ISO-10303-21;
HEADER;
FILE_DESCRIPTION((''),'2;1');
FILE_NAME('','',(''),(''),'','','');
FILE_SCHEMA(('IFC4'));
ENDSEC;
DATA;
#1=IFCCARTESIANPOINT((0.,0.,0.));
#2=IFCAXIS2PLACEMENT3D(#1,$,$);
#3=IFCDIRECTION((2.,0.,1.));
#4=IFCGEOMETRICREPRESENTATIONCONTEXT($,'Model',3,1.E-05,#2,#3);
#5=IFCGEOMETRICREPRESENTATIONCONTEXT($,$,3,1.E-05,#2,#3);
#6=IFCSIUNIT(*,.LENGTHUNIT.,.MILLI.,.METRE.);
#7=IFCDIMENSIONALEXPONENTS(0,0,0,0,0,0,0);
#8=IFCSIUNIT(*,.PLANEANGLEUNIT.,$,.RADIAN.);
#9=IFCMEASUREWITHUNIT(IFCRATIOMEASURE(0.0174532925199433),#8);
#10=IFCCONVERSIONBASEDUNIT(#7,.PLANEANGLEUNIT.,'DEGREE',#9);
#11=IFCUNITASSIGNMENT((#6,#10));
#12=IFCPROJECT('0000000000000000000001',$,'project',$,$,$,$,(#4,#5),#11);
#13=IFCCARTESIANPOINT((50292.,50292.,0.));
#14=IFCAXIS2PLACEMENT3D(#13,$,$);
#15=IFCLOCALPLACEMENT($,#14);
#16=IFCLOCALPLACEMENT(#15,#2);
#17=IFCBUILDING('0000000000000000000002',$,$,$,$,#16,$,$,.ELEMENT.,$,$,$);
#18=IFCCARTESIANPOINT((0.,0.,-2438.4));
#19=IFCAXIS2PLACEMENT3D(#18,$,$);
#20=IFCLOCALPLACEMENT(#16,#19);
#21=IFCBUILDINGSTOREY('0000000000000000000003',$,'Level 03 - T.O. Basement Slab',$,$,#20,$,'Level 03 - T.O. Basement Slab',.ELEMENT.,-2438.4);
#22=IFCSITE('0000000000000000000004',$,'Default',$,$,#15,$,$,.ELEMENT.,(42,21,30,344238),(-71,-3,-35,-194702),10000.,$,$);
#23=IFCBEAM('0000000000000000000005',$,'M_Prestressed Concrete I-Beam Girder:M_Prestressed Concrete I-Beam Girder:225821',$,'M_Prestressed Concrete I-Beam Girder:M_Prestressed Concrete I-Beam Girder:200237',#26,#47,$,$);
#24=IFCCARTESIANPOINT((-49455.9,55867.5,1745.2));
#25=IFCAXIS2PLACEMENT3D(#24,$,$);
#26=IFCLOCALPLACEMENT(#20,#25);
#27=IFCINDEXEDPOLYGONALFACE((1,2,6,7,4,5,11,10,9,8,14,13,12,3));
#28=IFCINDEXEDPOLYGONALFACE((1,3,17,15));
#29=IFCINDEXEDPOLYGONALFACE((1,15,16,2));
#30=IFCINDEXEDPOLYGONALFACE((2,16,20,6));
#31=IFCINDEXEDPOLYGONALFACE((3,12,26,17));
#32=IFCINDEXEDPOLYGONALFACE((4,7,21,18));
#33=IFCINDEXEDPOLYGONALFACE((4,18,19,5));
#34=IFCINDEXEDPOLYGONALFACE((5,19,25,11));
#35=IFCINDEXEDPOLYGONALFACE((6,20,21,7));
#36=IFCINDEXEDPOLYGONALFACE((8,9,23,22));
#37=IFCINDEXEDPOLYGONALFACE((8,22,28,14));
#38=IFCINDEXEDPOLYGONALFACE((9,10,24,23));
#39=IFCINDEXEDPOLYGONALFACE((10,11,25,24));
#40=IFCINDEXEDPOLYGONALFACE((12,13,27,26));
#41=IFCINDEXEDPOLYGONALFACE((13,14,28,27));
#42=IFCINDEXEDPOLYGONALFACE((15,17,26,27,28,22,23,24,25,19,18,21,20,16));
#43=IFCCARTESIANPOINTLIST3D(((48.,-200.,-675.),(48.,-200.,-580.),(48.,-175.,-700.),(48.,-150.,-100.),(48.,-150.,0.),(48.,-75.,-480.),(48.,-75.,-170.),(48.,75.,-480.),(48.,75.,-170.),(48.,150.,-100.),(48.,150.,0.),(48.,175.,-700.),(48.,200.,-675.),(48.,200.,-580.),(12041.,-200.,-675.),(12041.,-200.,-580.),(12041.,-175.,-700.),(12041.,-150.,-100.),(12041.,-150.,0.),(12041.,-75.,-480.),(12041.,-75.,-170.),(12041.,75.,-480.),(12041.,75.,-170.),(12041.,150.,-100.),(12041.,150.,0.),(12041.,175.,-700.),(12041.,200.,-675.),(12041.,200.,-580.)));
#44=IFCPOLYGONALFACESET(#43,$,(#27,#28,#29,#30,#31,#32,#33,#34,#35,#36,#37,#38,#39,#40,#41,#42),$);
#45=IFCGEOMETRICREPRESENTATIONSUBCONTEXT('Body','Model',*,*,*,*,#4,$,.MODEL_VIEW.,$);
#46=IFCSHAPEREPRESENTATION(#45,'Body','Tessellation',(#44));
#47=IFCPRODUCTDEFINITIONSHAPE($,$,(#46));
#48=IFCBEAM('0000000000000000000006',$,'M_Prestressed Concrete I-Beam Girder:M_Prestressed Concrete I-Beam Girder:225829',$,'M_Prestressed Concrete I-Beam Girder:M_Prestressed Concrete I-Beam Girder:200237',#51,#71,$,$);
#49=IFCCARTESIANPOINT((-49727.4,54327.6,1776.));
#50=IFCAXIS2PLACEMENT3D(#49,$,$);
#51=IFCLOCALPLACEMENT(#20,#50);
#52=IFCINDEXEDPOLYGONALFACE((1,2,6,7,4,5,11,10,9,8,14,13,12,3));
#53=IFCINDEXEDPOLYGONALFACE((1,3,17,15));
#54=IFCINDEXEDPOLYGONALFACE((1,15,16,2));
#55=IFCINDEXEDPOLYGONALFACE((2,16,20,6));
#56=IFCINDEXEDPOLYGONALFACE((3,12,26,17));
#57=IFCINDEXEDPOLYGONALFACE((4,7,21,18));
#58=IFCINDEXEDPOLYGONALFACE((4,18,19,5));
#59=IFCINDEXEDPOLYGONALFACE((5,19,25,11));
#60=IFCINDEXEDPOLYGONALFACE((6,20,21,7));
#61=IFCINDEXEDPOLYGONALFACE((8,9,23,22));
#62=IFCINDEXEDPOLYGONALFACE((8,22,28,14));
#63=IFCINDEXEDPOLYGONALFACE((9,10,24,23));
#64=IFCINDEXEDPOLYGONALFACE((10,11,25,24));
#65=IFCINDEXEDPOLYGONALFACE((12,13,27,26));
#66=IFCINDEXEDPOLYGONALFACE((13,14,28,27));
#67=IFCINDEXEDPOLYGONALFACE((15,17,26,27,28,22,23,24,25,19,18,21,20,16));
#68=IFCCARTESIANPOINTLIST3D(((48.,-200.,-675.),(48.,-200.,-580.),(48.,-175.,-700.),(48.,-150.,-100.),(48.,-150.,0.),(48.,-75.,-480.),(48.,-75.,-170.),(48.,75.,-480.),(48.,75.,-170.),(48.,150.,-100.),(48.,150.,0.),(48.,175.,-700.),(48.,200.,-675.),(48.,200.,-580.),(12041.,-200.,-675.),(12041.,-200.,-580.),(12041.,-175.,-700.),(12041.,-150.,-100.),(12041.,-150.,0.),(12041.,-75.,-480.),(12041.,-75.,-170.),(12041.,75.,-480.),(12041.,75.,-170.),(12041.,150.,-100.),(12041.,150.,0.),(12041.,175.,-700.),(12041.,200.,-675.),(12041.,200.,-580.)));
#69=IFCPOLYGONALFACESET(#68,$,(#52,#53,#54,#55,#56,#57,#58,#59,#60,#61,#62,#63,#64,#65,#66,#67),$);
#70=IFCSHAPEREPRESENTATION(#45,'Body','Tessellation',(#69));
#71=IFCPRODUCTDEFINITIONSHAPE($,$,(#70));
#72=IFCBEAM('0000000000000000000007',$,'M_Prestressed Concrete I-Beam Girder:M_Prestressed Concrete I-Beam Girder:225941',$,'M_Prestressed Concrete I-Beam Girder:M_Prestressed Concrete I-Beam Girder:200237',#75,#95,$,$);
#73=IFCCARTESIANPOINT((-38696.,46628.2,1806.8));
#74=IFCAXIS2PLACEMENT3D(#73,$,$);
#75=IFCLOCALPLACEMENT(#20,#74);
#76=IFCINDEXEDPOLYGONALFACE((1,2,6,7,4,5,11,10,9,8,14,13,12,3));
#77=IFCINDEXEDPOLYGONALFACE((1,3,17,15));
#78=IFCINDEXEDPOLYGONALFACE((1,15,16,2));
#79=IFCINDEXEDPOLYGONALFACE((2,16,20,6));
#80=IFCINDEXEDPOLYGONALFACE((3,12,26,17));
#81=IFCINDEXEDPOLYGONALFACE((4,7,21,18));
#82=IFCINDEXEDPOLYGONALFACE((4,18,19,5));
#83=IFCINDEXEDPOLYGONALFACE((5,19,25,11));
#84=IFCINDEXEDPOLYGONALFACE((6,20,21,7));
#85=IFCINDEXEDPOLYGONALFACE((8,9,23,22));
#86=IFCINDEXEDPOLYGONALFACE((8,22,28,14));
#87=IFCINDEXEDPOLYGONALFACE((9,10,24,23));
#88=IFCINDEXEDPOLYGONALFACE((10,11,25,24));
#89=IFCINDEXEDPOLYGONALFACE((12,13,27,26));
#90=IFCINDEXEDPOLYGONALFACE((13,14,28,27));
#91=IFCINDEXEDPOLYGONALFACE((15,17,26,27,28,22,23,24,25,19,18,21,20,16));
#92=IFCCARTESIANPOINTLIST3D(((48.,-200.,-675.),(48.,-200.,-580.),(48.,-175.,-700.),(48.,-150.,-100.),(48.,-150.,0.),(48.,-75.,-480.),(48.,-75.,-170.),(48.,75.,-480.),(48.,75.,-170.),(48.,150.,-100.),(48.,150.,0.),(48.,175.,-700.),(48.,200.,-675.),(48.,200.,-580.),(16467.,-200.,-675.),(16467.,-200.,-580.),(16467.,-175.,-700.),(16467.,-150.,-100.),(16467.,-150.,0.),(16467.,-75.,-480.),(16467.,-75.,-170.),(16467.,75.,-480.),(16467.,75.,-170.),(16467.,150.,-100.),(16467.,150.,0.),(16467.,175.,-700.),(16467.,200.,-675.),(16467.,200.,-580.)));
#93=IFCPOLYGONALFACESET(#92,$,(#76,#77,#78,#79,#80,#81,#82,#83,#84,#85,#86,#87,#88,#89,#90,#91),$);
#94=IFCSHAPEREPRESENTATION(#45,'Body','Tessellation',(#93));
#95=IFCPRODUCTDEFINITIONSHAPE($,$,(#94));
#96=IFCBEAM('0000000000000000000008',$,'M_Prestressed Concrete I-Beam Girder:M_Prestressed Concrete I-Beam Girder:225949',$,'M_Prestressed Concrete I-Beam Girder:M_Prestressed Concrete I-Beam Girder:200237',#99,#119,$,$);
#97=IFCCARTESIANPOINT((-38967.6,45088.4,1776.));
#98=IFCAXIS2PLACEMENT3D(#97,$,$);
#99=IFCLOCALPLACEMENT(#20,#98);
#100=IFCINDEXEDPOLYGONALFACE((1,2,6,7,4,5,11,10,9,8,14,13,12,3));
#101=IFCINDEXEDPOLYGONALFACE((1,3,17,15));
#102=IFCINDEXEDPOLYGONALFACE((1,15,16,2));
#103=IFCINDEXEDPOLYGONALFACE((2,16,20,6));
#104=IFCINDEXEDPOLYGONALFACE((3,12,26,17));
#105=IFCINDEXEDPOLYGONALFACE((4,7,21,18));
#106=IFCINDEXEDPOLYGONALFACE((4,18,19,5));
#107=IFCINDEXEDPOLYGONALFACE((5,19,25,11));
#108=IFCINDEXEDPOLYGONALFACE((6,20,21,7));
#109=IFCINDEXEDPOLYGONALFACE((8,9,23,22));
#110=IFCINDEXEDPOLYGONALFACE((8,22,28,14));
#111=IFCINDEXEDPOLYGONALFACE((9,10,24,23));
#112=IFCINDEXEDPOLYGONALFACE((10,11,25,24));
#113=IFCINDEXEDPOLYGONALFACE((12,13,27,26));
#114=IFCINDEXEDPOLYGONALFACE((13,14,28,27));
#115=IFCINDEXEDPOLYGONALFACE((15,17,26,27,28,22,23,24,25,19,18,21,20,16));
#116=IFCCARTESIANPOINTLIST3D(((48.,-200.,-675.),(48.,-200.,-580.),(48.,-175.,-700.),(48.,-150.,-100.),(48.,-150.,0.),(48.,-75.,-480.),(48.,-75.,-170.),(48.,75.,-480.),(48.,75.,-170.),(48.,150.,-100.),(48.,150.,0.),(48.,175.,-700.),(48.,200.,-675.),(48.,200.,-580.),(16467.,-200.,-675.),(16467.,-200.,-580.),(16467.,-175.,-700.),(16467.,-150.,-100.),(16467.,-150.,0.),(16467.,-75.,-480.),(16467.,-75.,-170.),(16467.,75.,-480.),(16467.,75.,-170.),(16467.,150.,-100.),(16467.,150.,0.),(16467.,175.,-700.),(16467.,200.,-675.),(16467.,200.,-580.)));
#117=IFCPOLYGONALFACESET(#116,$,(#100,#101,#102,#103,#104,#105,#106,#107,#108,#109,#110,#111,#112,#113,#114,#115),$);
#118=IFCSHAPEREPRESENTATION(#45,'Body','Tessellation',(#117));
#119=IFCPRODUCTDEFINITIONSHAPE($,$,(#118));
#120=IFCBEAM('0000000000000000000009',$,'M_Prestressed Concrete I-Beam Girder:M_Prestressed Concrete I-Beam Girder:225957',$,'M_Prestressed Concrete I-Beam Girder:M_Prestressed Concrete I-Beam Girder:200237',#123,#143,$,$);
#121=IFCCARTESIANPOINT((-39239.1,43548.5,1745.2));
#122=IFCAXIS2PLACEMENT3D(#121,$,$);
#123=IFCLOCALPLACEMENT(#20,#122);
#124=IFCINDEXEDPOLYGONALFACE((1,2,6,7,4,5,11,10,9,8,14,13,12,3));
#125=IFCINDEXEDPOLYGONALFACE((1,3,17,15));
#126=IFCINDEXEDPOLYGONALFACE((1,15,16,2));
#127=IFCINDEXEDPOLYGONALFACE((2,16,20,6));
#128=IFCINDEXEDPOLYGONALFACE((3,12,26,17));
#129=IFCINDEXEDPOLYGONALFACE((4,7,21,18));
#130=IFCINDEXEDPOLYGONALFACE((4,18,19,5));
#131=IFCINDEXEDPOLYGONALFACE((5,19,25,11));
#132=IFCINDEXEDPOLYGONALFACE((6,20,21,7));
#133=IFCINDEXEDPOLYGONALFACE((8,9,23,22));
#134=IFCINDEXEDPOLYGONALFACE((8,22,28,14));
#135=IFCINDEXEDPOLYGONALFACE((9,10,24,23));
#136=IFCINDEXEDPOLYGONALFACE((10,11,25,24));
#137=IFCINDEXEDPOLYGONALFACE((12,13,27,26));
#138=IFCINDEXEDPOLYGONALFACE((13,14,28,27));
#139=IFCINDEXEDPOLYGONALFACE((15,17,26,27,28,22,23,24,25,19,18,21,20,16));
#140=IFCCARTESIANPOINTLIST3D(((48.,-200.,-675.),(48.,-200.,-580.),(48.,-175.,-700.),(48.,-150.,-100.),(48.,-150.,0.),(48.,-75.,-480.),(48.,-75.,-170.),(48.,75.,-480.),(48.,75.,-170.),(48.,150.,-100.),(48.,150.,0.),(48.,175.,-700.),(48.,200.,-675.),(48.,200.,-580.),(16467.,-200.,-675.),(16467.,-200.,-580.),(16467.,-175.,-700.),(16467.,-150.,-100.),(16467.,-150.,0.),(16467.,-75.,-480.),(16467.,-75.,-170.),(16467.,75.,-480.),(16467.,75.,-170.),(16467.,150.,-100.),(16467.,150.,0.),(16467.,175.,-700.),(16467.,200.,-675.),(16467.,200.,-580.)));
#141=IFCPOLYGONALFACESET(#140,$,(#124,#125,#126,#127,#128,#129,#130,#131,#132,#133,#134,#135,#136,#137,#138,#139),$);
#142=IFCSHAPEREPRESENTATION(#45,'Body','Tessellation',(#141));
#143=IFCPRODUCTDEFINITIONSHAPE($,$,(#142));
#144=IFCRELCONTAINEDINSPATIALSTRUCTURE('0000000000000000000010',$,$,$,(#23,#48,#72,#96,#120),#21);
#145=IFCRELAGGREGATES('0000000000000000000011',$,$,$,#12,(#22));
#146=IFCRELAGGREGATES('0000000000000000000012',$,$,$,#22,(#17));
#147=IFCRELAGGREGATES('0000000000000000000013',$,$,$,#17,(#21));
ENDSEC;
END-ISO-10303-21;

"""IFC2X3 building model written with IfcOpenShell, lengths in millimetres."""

from ifc_helpers import new_model, entity, si_unit, converted_unit, direction, frame, origin, place, context, subcontext, project, spatial, polyline, outline, extrude, element, save


model = new_model("IFC2X3")

# Units and contexts
model_context = context("Model", 3, precision=1e-05, world=origin(), true_north=direction((2.0, 0.0, 1.0)))
context_of_model = context(None, 3, precision=1e-05, world=origin(), true_north=direction((2.0, 0.0, 1.0)))
body_context = subcontext(model_context, "Body", "Model", "MODEL_VIEW")
ifc_project = project(units=[si_unit("LENGTHUNIT", "METRE", prefix="MILLI"), converted_unit("PLANEANGLEUNIT", "DEGREE", entity("IfcRatioMeasure", 0.0174532925199433), si_unit("PLANEANGLEUNIT", "RADIAN"), dimensions=[0, 0, 0, 0, 0, 0, 0])], contexts=[model_context, context_of_model])

# Site, building, storey
site_placement = place(None, frame((50292.0, 50292.0, 0.0)))
site = spatial("IfcSite", under=ifc_project, at=site_placement, Name="Default", CompositionType="ELEMENT", RefLatitude=(42, 21, 30, 344238), RefLongitude=(-71, -3, -35, -194702), RefElevation=10000.0)
building_placement = place(site_placement, origin())
building = spatial("IfcBuilding", under=site, at=building_placement, CompositionType="ELEMENT")
storey_placement = place(building_placement, frame((0.0, 0.0, -2438.4)))
storey = spatial("IfcBuildingStorey", under=building, at=storey_placement, Name="Level 03 - T.O. Basement Slab", LongName="Level 03 - T.O. Basement Slab", CompositionType="ELEMENT", Elevation=-2438.4)

# Beams
beam_1_placement = place(storey_placement, frame((-49455.9, 55867.5, 1745.2)))
element("IfcBeam", 1, at=beam_1_placement, inside=storey, Name="M_Prestressed Concrete I-Beam Girder:M_Prestressed Concrete I-Beam Girder:225821", ObjectType="M_Prestressed Concrete I-Beam Girder:M_Prestressed Concrete I-Beam Girder:200237", context=body_context, shape_type="SweptSolid", body=[
    extrude(outline(polyline([(193.6, -200.0), (288.6, -200.0), (313.6, -175.0), (313.6, 175.0), (288.6, 200.0), (193.6, 200.0), (93.6, 75.0), (-216.4, 75.0), (-286.4, 150.0), (-386.4, 150.0), (-386.4, -150.0), (-286.4, -150.0), (-216.4, -75.0), (93.6, -75.0), (193.6, -200.0)])), frame((48.0, 0.0, -386.4), z_axis=(1.0, 0.0, 0.0), x_axis=(0.0, 0.0, -1.0)), (0.0, 0.0, 1.0), 11993.0),
])
beam_2_placement = place(storey_placement, frame((-49727.4, 54327.6, 1776.0)))
element("IfcBeam", 2, at=beam_2_placement, inside=storey, Name="M_Prestressed Concrete I-Beam Girder:M_Prestressed Concrete I-Beam Girder:225829", ObjectType="M_Prestressed Concrete I-Beam Girder:M_Prestressed Concrete I-Beam Girder:200237", context=body_context, shape_type="SweptSolid", body=[
    extrude(outline(polyline([(193.6, -200.0), (288.6, -200.0), (313.6, -175.0), (313.6, 175.0), (288.6, 200.0), (193.6, 200.0), (93.6, 75.0), (-216.4, 75.0), (-286.4, 150.0), (-386.4, 150.0), (-386.4, -150.0), (-286.4, -150.0), (-216.4, -75.0), (93.6, -75.0), (193.6, -200.0)])), frame((48.0, 0.0, -386.4), z_axis=(1.0, 0.0, 0.0), x_axis=(0.0, 0.0, -1.0)), (0.0, 0.0, 1.0), 11993.0),
])
beam_3_placement = place(storey_placement, frame((-38696.0, 46628.2, 1806.8)))
element("IfcBeam", 3, at=beam_3_placement, inside=storey, Name="M_Prestressed Concrete I-Beam Girder:M_Prestressed Concrete I-Beam Girder:225941", ObjectType="M_Prestressed Concrete I-Beam Girder:M_Prestressed Concrete I-Beam Girder:200237", context=body_context, shape_type="SweptSolid", body=[
    extrude(outline(polyline([(193.6, -200.0), (288.6, -200.0), (313.6, -175.0), (313.6, 175.0), (288.6, 200.0), (193.6, 200.0), (93.6, 75.0), (-216.4, 75.0), (-286.4, 150.0), (-386.4, 150.0), (-386.4, -150.0), (-286.4, -150.0), (-216.4, -75.0), (93.6, -75.0), (193.6, -200.0)])), frame((48.0, 0.0, -386.4), z_axis=(1.0, 0.0, 0.0), x_axis=(0.0, 0.0, -1.0)), (0.0, 0.0, 1.0), 16419.0),
])
beam_4_placement = place(storey_placement, frame((-38967.6, 45088.4, 1776.0)))
element("IfcBeam", 4, at=beam_4_placement, inside=storey, Name="M_Prestressed Concrete I-Beam Girder:M_Prestressed Concrete I-Beam Girder:225949", ObjectType="M_Prestressed Concrete I-Beam Girder:M_Prestressed Concrete I-Beam Girder:200237", context=body_context, shape_type="SweptSolid", body=[
    extrude(outline(polyline([(193.6, -200.0), (288.6, -200.0), (313.6, -175.0), (313.6, 175.0), (288.6, 200.0), (193.6, 200.0), (93.6, 75.0), (-216.4, 75.0), (-286.4, 150.0), (-386.4, 150.0), (-386.4, -150.0), (-286.4, -150.0), (-216.4, -75.0), (93.6, -75.0), (193.6, -200.0)])), frame((48.0, 0.0, -386.4), z_axis=(1.0, 0.0, 0.0), x_axis=(0.0, 0.0, -1.0)), (0.0, 0.0, 1.0), 16419.0),
])
beam_5_placement = place(storey_placement, frame((-39239.1, 43548.5, 1745.2)))
element("IfcBeam", 5, at=beam_5_placement, inside=storey, Name="M_Prestressed Concrete I-Beam Girder:M_Prestressed Concrete I-Beam Girder:225957", ObjectType="M_Prestressed Concrete I-Beam Girder:M_Prestressed Concrete I-Beam Girder:200237", context=body_context, shape_type="SweptSolid", body=[
    extrude(outline(polyline([(193.6, -200.0), (288.6, -200.0), (313.6, -175.0), (313.6, 175.0), (288.6, 200.0), (193.6, 200.0), (93.6, 75.0), (-216.4, 75.0), (-286.4, 150.0), (-386.4, 150.0), (-386.4, -150.0), (-286.4, -150.0), (-216.4, -75.0), (93.6, -75.0), (193.6, -200.0)])), frame((48.0, 0.0, -386.4), z_axis=(1.0, 0.0, 0.0), x_axis=(0.0, 0.0, -1.0)), (0.0, 0.0, 1.0), 16419.0),
])

save(model, "model.ifc")
